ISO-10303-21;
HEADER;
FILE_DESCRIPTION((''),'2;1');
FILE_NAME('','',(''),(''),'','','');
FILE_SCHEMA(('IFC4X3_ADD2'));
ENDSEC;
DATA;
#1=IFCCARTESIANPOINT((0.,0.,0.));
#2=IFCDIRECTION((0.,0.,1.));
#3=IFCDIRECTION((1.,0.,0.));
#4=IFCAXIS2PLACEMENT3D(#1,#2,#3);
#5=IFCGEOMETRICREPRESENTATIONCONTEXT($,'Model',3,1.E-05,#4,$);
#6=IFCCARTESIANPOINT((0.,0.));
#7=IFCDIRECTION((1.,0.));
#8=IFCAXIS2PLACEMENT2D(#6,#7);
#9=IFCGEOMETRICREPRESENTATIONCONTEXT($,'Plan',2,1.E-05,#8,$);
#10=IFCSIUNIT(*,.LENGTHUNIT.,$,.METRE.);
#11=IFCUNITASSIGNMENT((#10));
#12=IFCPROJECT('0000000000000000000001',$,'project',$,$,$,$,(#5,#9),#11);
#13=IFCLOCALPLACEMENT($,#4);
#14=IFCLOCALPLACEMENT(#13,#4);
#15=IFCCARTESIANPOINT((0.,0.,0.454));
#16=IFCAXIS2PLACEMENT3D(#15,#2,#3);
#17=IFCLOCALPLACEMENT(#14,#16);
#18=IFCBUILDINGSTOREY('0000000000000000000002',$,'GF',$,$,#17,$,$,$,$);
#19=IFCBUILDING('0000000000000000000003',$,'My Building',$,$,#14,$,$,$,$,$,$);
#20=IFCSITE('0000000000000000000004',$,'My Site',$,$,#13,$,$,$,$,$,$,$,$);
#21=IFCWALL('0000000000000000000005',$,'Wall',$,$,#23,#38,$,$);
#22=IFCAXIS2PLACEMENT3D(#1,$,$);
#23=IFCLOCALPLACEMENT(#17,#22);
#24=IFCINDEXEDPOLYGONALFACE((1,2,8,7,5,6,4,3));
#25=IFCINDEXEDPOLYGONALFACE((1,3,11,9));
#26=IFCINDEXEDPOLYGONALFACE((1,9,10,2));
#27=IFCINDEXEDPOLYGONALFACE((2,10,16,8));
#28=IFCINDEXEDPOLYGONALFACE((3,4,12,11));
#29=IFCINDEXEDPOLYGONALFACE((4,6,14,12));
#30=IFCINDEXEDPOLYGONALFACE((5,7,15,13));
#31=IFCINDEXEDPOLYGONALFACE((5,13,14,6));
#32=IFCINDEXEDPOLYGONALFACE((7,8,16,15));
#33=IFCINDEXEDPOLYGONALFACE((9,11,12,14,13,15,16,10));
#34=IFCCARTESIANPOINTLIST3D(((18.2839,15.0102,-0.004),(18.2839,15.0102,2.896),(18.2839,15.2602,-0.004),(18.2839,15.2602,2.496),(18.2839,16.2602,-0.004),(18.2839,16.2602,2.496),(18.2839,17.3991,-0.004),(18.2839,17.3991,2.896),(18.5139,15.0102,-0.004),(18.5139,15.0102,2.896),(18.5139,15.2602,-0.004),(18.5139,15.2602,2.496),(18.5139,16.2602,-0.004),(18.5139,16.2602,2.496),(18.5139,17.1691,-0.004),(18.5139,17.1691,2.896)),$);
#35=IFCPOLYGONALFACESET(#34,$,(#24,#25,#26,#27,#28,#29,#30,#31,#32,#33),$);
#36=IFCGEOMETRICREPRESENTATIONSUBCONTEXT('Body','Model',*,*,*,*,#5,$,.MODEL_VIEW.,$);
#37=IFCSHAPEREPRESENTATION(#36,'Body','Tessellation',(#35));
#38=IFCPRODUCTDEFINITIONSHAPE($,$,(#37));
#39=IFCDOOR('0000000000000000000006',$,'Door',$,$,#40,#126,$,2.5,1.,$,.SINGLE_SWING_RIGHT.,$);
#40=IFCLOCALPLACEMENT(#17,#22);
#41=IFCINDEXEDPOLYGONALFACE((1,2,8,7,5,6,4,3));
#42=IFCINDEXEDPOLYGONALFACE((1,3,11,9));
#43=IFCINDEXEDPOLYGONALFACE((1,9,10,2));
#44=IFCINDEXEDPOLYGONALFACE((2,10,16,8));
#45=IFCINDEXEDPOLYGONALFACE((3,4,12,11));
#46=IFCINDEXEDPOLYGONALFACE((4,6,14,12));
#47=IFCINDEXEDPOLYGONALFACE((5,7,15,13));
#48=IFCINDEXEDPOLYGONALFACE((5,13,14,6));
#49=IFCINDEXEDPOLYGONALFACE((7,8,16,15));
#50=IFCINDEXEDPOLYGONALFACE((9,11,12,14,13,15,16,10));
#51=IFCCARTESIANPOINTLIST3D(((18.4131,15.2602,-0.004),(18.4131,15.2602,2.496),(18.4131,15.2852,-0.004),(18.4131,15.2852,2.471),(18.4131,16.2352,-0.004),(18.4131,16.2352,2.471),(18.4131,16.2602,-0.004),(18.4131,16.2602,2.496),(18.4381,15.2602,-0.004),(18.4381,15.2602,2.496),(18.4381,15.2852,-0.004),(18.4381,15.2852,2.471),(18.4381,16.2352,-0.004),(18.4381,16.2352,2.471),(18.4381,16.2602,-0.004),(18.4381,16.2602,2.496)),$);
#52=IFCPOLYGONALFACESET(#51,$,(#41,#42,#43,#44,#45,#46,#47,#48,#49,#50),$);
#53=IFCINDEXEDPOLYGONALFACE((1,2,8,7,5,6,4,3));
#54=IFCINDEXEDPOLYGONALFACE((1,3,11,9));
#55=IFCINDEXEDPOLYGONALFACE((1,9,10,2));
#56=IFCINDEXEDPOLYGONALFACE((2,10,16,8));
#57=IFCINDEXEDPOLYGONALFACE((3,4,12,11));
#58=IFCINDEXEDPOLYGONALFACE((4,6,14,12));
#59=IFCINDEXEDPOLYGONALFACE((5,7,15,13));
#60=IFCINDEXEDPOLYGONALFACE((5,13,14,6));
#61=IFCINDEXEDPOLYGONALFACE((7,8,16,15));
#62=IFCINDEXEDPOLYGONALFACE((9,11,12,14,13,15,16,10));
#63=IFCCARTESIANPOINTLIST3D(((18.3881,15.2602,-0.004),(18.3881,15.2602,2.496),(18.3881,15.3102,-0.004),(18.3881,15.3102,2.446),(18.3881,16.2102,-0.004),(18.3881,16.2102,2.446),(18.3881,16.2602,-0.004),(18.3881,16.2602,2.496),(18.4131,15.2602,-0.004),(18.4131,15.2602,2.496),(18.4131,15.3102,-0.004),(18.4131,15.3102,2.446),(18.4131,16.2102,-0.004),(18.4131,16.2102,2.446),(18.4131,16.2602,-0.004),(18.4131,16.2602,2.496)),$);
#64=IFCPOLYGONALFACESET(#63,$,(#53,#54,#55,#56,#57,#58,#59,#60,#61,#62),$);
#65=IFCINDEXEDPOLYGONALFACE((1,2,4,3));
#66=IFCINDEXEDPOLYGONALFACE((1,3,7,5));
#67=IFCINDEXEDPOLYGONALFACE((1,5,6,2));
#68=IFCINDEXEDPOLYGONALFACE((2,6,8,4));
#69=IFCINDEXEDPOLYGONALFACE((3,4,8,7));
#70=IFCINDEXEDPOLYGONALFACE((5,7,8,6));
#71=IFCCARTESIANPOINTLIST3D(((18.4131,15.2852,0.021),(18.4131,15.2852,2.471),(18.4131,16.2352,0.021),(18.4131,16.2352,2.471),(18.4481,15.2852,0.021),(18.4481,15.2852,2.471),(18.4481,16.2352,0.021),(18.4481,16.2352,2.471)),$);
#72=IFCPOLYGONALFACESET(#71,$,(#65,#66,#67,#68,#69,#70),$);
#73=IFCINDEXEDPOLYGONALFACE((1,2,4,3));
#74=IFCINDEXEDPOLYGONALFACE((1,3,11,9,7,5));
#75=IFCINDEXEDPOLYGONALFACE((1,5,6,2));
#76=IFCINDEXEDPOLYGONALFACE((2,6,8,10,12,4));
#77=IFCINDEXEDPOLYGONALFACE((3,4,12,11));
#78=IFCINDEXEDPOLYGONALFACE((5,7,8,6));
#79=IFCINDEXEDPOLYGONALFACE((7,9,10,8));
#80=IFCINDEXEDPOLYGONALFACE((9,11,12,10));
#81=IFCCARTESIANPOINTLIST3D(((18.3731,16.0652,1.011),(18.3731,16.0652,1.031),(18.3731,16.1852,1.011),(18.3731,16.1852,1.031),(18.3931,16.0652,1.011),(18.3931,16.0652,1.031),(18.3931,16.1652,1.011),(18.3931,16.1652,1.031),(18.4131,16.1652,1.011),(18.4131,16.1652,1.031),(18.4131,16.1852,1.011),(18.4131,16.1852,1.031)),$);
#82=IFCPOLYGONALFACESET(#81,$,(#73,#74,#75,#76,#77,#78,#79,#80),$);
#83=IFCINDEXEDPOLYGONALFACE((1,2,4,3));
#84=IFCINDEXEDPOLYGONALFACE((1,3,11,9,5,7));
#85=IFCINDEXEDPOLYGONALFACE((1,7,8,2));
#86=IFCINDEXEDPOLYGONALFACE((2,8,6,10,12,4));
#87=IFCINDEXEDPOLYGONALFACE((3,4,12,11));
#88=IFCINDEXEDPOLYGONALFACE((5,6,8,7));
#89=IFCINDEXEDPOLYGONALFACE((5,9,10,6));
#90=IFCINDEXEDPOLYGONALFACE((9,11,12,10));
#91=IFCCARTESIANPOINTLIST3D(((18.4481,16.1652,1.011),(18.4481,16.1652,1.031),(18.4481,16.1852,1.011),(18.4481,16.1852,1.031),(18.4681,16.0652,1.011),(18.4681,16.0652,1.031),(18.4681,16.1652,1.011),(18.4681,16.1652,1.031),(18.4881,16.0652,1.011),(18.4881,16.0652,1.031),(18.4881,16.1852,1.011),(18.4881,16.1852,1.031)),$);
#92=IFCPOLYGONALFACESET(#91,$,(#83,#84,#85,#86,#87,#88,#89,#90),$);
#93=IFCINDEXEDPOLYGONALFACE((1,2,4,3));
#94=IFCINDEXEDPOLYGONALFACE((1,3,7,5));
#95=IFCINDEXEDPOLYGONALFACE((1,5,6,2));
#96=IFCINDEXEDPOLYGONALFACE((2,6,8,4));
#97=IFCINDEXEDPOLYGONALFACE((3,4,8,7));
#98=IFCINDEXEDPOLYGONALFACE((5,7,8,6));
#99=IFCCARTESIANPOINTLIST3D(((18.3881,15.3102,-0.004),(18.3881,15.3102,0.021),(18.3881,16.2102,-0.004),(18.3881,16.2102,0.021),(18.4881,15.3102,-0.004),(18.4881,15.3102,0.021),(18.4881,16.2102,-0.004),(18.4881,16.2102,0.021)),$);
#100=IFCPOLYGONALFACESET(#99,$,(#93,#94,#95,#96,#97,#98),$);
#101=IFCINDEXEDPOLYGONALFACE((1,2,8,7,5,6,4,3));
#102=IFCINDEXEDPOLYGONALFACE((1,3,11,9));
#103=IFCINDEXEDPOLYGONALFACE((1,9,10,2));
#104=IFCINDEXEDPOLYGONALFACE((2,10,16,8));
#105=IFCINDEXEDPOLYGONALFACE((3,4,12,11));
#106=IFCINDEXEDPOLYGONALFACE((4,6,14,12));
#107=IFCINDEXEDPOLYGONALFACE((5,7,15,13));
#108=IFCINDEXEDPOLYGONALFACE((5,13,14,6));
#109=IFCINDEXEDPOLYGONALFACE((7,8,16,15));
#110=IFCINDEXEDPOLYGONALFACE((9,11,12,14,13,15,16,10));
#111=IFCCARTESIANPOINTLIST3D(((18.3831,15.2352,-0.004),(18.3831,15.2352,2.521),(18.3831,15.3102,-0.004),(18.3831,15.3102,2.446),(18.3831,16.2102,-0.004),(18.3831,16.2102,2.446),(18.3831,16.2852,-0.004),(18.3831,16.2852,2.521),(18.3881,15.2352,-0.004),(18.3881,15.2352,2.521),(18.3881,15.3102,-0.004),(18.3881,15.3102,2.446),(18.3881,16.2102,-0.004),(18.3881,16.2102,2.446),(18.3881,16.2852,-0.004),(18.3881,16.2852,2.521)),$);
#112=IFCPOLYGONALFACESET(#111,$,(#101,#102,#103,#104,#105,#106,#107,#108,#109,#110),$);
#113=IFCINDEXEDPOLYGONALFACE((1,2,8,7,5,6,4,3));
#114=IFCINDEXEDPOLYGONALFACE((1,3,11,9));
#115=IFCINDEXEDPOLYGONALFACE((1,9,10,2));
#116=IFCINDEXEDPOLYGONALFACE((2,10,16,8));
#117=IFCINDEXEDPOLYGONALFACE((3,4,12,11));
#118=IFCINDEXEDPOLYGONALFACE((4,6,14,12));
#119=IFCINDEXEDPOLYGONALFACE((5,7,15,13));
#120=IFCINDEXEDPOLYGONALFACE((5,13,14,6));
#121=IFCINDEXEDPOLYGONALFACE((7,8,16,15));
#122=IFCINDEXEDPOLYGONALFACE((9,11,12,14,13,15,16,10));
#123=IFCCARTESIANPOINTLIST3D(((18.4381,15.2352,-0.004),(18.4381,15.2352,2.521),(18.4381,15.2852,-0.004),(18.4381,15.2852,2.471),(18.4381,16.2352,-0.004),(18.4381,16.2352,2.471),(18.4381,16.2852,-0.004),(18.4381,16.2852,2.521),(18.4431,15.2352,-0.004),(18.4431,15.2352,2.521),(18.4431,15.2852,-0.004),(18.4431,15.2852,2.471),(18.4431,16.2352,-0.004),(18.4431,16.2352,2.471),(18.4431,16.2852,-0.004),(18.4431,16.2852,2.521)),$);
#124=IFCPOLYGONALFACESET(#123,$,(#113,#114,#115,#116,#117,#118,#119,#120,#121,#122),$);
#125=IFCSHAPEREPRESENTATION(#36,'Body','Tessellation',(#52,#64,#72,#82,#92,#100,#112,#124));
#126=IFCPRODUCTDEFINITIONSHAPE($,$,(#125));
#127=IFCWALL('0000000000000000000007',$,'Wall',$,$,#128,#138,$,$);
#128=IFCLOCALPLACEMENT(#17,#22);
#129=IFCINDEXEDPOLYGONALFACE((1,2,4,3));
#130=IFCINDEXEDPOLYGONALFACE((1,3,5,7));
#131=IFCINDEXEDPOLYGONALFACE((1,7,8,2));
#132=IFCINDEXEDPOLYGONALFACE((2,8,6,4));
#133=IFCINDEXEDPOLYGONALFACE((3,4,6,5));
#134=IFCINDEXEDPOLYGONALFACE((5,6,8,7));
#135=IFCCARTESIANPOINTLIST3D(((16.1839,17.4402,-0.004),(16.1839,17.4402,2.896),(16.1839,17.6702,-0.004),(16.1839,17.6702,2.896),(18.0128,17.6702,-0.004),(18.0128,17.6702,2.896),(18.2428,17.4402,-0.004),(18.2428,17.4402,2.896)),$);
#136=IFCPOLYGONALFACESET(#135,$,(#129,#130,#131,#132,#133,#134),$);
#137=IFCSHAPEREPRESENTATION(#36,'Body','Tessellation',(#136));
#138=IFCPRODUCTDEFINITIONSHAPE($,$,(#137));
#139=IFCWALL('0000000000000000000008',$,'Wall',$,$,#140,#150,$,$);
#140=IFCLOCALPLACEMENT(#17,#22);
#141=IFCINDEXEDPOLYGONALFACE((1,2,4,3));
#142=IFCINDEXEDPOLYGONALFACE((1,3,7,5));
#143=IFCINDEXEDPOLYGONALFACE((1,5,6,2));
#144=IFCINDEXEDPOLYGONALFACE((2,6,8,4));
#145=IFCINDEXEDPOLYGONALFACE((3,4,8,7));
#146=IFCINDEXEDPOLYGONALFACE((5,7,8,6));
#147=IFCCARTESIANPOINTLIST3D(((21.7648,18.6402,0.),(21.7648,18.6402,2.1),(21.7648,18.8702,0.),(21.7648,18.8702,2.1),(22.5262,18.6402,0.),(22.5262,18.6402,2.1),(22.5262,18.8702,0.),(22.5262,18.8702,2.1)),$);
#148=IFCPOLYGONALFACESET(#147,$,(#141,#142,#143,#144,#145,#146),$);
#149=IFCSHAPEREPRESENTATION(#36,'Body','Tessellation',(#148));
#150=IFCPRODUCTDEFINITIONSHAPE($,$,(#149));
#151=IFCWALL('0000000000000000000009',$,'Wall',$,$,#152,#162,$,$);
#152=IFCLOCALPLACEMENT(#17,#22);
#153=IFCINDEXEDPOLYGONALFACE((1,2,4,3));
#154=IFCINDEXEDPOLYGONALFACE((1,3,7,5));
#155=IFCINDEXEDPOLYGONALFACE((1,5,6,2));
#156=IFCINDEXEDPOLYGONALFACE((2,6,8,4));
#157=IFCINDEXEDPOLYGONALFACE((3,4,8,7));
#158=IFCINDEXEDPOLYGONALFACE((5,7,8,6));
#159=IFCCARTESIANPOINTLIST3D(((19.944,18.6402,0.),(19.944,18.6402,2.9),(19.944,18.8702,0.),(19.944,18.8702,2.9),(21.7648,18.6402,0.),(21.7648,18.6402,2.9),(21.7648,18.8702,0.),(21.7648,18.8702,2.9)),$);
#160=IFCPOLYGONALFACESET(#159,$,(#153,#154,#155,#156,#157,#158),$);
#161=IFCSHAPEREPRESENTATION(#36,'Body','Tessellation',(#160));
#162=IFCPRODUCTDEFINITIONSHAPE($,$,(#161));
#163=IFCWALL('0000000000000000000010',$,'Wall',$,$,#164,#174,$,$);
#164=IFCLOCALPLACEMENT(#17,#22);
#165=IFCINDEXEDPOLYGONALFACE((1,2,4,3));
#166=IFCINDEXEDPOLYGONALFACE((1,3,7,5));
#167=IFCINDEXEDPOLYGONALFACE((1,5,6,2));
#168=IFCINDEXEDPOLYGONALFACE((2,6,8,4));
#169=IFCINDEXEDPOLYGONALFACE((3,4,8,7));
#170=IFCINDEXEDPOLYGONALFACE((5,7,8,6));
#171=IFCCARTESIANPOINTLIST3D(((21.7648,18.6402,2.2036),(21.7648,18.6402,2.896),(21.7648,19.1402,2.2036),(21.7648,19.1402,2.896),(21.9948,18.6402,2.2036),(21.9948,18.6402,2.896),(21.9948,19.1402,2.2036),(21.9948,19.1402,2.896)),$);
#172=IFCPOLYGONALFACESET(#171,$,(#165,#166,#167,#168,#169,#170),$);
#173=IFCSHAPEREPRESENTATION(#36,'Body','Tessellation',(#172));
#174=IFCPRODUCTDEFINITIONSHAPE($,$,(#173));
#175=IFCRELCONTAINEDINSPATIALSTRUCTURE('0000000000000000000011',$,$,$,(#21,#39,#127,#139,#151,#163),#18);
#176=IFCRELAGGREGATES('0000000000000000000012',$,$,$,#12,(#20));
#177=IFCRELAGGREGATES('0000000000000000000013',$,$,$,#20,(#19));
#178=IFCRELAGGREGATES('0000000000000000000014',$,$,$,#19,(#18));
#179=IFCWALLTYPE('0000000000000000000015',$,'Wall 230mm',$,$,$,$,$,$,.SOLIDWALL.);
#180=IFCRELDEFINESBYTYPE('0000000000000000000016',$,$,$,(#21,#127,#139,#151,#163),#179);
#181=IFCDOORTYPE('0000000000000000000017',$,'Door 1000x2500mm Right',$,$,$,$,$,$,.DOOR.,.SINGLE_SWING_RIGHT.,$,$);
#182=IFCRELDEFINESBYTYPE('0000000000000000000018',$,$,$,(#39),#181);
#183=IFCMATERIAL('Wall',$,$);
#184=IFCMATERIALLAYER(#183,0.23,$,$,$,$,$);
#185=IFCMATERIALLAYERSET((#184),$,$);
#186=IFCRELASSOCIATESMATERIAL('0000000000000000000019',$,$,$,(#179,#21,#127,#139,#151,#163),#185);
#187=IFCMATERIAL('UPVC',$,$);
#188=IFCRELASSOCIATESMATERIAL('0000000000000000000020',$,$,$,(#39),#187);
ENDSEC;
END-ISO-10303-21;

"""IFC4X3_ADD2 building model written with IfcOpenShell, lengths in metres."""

from ifc_helpers import new_model, entity, si_unit, frame, origin_with_axes, origin_2d_with_axis, place, context, subcontext, project, spatial, line, indexed_curve, outline, extrude, clip, halfspace, shape, source, transform, mapped, material, layer, layer_set, layer_usage, type_object, type_shapes, element, fill, save


model = new_model("IFC4X3_ADD2")

# Units and contexts
model_context = context("Model", 3, precision=1e-05, world=origin_with_axes())
plan_context = context("Plan", 2, precision=1e-05, world=origin_2d_with_axis())
body_context_1 = subcontext(model_context, "Body", "Model", "MODEL_VIEW")
body_context_2 = subcontext(plan_context, "Body", "Plan", "PLAN_VIEW")
ifc_project = project(units=[si_unit("LENGTHUNIT", "METRE")], contexts=[model_context, plan_context])

# Site, building, storey
site_placement = place(None, origin_with_axes())
site = spatial("IfcSite", under=ifc_project, at=site_placement, Name="My Site")
building_placement = place(site_placement, origin_with_axes())
building = spatial("IfcBuilding", under=site, at=building_placement, Name="My Building")
storey_placement = place(building_placement, frame((0.0, 0.0, 0.454), z_axis=(0.0, 0.0, 1.0), x_axis=(1.0, 0.0, 0.0)))
storey = spatial("IfcBuildingStorey", under=building, at=storey_placement, Name="GF")

# Shared definitions
ifc_material_1 = material(Name="UPVC")

# Shared definitions
ifc_material_2 = material(Name="Wall")
ifc_layer_1 = layer(ifc_material_2, 0.23)
ifc_layer_set_1 = layer_set([ifc_layer_1])
wall_type = type_object("IfcWallType", Name="Wall 230mm", PredefinedType="SOLIDWALL", material=ifc_layer_set_1)

# Wall, opening, door
ifc_layer_usage_1 = layer_usage(ifc_layer_set_1, "AXIS2", "POSITIVE", 0.0)
wall_1_placement = place(storey_placement, frame((18.5139, 15.0102, -0.004), z_axis=(0.0, 0.0, 1.0), x_axis=(0.000001, 1.0, 0.0)))
wall_1 = element("IfcWall", 1, at=wall_1_placement, inside=storey, type_object=wall_type, material=ifc_layer_usage_1, Name="Wall", context=body_context_1, shape_type="Clipping", body=[
    clip(extrude(outline(indexed_curve([(0.0, 0.0), (0.0, 0.23), (2.3889, 0.23), (2.3889, 0.0), (0.0, 0.0)], self_intersect=False)), origin_with_axes(), (0.0, 0.0, 1.0), 2.9), halfspace(frame((2.1589, 0.0, -0.45), z_axis=(0.666999, -0.666998, 0.0), x_axis=(-0.707106, -0.707107, 0.0)), False)),
])
shared_shape_1 = source(origin_with_axes(), body_context_1, "Body", "SweptSolid", [
    extrude(outline(indexed_curve([(0.0, 0.0), (1.0, 0.0), (1.0, 2.5), (0.0, 2.5)], segments=[line(1, 2, 3, 4, 1)])), frame((0.0, -0.6, 0.0), z_axis=(0.0, -1.0, 0.0), x_axis=(1.0, 0.0, 0.0)), (0.0, 0.0, -1.0), 1.2),
])
opening_1_placement = place(wall_1_placement, frame((1.25, 0.1258, 0.0), z_axis=(0.0, 0.0, 1.0), x_axis=(-1.0, 0.0, 0.0)))
opening_1 = element("IfcOpeningElement", 2, at=opening_1_placement, cuts=wall_1, PredefinedType="OPENING", context=body_context_1, shape_type="MappedRepresentation", body=[
    mapped(shared_shape_1, transform((0.0, 0.0, 0.0), x_axis=(1.0, 0.0, 0.0), y_axis=(0.0, 1.0, 0.0), z_axis=(0.0, 0.0, 1.0), scale=1.0)),
])
door_type_1 = type_object("IfcDoorType", Name="Door 1000x2500mm Right", OperationType="SINGLE_SWING_RIGHT", PredefinedType="DOOR")
shared_shape_2 = source(origin_with_axes(), body_context_1, "Body", "SweptSolid", [
    extrude(outline(indexed_curve([(0.0, 0.0), (0.0, 2.5), (1.0, 2.5), (1.0, 0.0), (0.975, 0.0), (0.975, 2.475), (0.025, 2.475), (0.025, 0.0)], segments=[line(1, 2, 3, 4, 5, 6, 7, 8, 1)])), frame((0.0, 0.025, 0.0), z_axis=(0.0, -1.0, 0.0), x_axis=(1.0, 0.0, 0.0)), (0.0, 0.0, -1.0), 0.025),
    extrude(outline(indexed_curve([(0.0, 0.0), (0.0, 2.5), (1.0, 2.5), (1.0, 0.0), (0.95, 0.0), (0.95, 2.45), (0.05, 2.45), (0.05, 0.0)], segments=[line(1, 2, 3, 4, 5, 6, 7, 8, 1)])), frame((0.0, 0.0, 0.0), z_axis=(0.0, -1.0, 0.0), x_axis=(1.0, 0.0, 0.0)), (0.0, 0.0, -1.0), 0.025),
    extrude(outline(indexed_curve([(0.0, 0.0), (0.95, 0.0), (0.95, 0.035), (0.0, 0.035)], segments=[line(1, 2, 3, 4, 1)])), frame((0.025, 0.025, 0.025), z_axis=(0.0, 0.0, 1.0), x_axis=(1.0, 0.0, 0.0)), (0.0, 0.0, 1.0), 2.45),
    extrude(outline(indexed_curve([(0.0, 0.0), (0.0, -0.04), (0.12, -0.04), (0.12, -0.02), (0.02, -0.02), (0.02, 0.0)], segments=[line(1, 2, 3, 4, 5, 6, 1)])), frame((0.075, 0.025, 1.015), z_axis=(0.0, 0.0, 1.0), x_axis=(1.0, 0.0, 0.0)), (0.0, 0.0, 1.0), 0.02),
    extrude(outline(indexed_curve([(0.0, 0.0), (0.0, 0.04), (0.12, 0.04), (0.12, 0.02), (0.02, 0.02), (0.02, 0.0)], segments=[line(1, 2, 3, 4, 5, 6, 1)])), frame((0.075, 0.06, 1.015), z_axis=(0.0, 0.0, 1.0), x_axis=(1.0, 0.0, 0.0)), (0.0, 0.0, 1.0), 0.02),
    extrude(outline(indexed_curve([(0.0, 0.0), (0.9, 0.0), (0.9, 0.1), (0.0, 0.1)], segments=[line(1, 2, 3, 4, 1)])), frame((0.05, 0.0, 0.0), z_axis=(0.0, 0.0, 1.0), x_axis=(1.0, 0.0, 0.0)), (0.0, 0.0, 1.0), 0.025),
    extrude(outline(indexed_curve([(0.0, 0.0), (0.0, 2.525), (1.05, 2.525), (1.05, 0.0), (0.975, 0.0), (0.975, 2.45), (0.075, 2.45), (0.075, 0.0)], segments=[line(1, 2, 3, 4, 5, 6, 7, 8, 1)])), frame((-0.025, -0.005, 0.0), z_axis=(0.0, -1.0, 0.0), x_axis=(1.0, 0.0, 0.0)), (0.0, 0.0, -1.0), 0.005),
    extrude(outline(indexed_curve([(0.0, 0.0), (0.0, 2.525), (1.05, 2.525), (1.05, 0.0), (1.0, 0.0), (1.0, 2.475), (0.05, 2.475), (0.05, 0.0)], segments=[line(1, 2, 3, 4, 5, 6, 7, 8, 1)])), frame((-0.025, 0.05, 0.0), z_axis=(0.0, -1.0, 0.0), x_axis=(1.0, 0.0, 0.0)), (0.0, 0.0, -1.0), 0.005),
])
shared_shape_3 = source(origin_with_axes(), body_context_2, "Body", "Curve2D", [
    entity("IfcIndexedPolyCurve", entity("IfcCartesianPointList2D", [[0.0, 0.0], [0.0, 0.05], [0.025, 0.05], [0.025, 0.025], [0.05, 0.025], [0.05, 0.0]]), [entity("IfcLineIndex", [1, 2, 3, 4, 5, 6, 1])]),
    entity("IfcIndexedPolyCurve", entity("IfcCartesianPointList2D", [[1.0, 0.0], [1.0, 0.05], [0.975, 0.05], [0.975, 0.025], [0.95, 0.025], [0.95, 0.0]]), [entity("IfcLineIndex", [1, 2, 3, 4, 5, 6, 1])]),
    entity("IfcTrimmedCurve", entity("IfcEllipse", entity("IfcAxis2Placement2D", entity("IfcCartesianPoint", [0.94, 0.05]), entity("IfcDirection", [1.0, 0.0])), 0.915, 0.95), [entity("IfcCartesianPoint", [0.94, 1.0])], [entity("IfcCartesianPoint", [0.025, 0.05])], True, "CARTESIAN"),
    entity("IfcIndexedPolyCurve", entity("IfcCartesianPointList2D", [[0.975, 0.05], [0.94, 0.05], [0.94, 1.0], [0.975, 1.0]]), [entity("IfcLineIndex", [1, 2, 3, 4, 1])]),
])
type_shapes(door_type_1, [shared_shape_2, shared_shape_3])
door_1_placement = place(opening_1_placement, frame((0.0, 0.0, 0.0), z_axis=(0.0, 0.0, 1.0), x_axis=(1.0, 0.0, 0.0)))
door_1 = element("IfcDoor", 3, at=door_1_placement, inside=storey, type_object=door_type_1, material=ifc_material_1, Name="Door", OperationType="SINGLE_SWING_RIGHT", OverallHeight=2.5, OverallWidth=1.0, shapes=[
    shape(body_context_1, "Body", "MappedRepresentation", [mapped(shared_shape_2, transform((0.0, 0.0, 0.0), x_axis=(1.0, 0.0, 0.0), y_axis=(0.0, 1.0, 0.0), z_axis=(0.0, 0.0, 1.0), scale=1.0))]),
    shape(body_context_2, "Body", "MappedRepresentation", [mapped(shared_shape_3, transform((0.0, 0.0, 0.0), x_axis=(1.0, 0.0, 0.0), y_axis=(0.0, 1.0, 0.0), z_axis=(0.0, 0.0, 1.0), scale=1.0))]),
])
fill(opening_1, door_1)

# Walls
ifc_layer_usage_2 = layer_usage(ifc_layer_set_1, "AXIS2", "POSITIVE", 0.0)
wall_2_placement = place(storey_placement, frame((18.2428, 17.6702, -0.004), z_axis=(0.0, 0.0, 1.0), x_axis=(-1.0, 0.0, 0.0)))
element("IfcWall", 4, at=wall_2_placement, inside=storey, type_object=wall_type, material=ifc_layer_usage_2, Name="Wall", context=body_context_1, shape_type="Clipping", body=[
    clip(extrude(outline(indexed_curve([(0.0, 0.0), (0.0, 0.23), (2.0589, 0.23), (2.0589, 0.0), (0.0, 0.0)], self_intersect=False)), origin_with_axes(), (0.0, 0.0, 1.0), 2.9), halfspace(frame((0.23, 0.0, -0.45), z_axis=(-0.666999, -0.666999, 0.0), x_axis=(-0.707107, 0.707107, 0.0)), False)),
])
ifc_layer_usage_3 = layer_usage(ifc_layer_set_1, "AXIS2", "POSITIVE", 0.0)
wall_3_placement = place(storey_placement, frame((21.7648, 18.6402, 0.0), z_axis=(0.0, 0.0, 1.0), x_axis=(1.0, -0.000001, 0.0)))
element("IfcWall", 5, at=wall_3_placement, inside=storey, type_object=wall_type, material=ifc_layer_usage_3, Name="Wall", context=body_context_1, shape_type="Clipping", body=[
    clip(extrude(outline(indexed_curve([(0.0, 0.0), (0.0, 0.23), (0.7614, 0.23), (0.7614, 0.0), (0.0, 0.0)], self_intersect=False)), origin_with_axes(), (0.0, 0.0, 1.0), 2.554), halfspace(frame((0.0, 0.0, 2.1), z_axis=(0.0, 0.0, 1.0), x_axis=(-1.0, 0.0, 0.0)), False)),
])
ifc_layer_usage_4 = layer_usage(ifc_layer_set_1, "AXIS2", "POSITIVE", 0.0)
wall_4_placement = place(storey_placement, frame((19.944, 18.6402, 0.0), z_axis=(0.0, 0.0, 1.0), x_axis=(1.0, -0.000001, 0.0)))
element("IfcWall", 6, at=wall_4_placement, inside=storey, type_object=wall_type, material=ifc_layer_usage_4, Name="Wall", context=body_context_1, shape_type="SweptSolid", body=[
    extrude(outline(indexed_curve([(0.0, 0.0), (0.0, 0.23), (1.8208, 0.23), (1.8208, 0.0), (0.0, 0.0)], self_intersect=False)), origin_with_axes(), (0.0, 0.0, 1.0), 2.9),
])
ifc_layer_usage_5 = layer_usage(ifc_layer_set_1, "AXIS2", "POSITIVE", 0.0)
wall_5_placement = place(storey_placement, frame((21.9948, 18.6402, 2.2036), z_axis=(0.0, 0.0, 1.0), x_axis=(0.000001, 1.0, 0.0)))
element("IfcWall", 7, at=wall_5_placement, inside=storey, type_object=wall_type, material=ifc_layer_usage_5, Name="Wall", context=body_context_1, shape_type="Clipping", body=[
    clip(extrude(outline(indexed_curve([(0.0, 0.0), (0.0, 0.23), (0.5, 0.23), (0.5, 0.0), (0.0, 0.0)], self_intersect=False)), origin_with_axes(), (0.0, 0.0, 1.0), 3.35), halfspace(frame((0.0, 0.0, 0.6924), z_axis=(0.0, 0.0, 1.0), x_axis=(-1.0, 0.0, 0.0)), False)),
])

save(model, "model.ifc")
